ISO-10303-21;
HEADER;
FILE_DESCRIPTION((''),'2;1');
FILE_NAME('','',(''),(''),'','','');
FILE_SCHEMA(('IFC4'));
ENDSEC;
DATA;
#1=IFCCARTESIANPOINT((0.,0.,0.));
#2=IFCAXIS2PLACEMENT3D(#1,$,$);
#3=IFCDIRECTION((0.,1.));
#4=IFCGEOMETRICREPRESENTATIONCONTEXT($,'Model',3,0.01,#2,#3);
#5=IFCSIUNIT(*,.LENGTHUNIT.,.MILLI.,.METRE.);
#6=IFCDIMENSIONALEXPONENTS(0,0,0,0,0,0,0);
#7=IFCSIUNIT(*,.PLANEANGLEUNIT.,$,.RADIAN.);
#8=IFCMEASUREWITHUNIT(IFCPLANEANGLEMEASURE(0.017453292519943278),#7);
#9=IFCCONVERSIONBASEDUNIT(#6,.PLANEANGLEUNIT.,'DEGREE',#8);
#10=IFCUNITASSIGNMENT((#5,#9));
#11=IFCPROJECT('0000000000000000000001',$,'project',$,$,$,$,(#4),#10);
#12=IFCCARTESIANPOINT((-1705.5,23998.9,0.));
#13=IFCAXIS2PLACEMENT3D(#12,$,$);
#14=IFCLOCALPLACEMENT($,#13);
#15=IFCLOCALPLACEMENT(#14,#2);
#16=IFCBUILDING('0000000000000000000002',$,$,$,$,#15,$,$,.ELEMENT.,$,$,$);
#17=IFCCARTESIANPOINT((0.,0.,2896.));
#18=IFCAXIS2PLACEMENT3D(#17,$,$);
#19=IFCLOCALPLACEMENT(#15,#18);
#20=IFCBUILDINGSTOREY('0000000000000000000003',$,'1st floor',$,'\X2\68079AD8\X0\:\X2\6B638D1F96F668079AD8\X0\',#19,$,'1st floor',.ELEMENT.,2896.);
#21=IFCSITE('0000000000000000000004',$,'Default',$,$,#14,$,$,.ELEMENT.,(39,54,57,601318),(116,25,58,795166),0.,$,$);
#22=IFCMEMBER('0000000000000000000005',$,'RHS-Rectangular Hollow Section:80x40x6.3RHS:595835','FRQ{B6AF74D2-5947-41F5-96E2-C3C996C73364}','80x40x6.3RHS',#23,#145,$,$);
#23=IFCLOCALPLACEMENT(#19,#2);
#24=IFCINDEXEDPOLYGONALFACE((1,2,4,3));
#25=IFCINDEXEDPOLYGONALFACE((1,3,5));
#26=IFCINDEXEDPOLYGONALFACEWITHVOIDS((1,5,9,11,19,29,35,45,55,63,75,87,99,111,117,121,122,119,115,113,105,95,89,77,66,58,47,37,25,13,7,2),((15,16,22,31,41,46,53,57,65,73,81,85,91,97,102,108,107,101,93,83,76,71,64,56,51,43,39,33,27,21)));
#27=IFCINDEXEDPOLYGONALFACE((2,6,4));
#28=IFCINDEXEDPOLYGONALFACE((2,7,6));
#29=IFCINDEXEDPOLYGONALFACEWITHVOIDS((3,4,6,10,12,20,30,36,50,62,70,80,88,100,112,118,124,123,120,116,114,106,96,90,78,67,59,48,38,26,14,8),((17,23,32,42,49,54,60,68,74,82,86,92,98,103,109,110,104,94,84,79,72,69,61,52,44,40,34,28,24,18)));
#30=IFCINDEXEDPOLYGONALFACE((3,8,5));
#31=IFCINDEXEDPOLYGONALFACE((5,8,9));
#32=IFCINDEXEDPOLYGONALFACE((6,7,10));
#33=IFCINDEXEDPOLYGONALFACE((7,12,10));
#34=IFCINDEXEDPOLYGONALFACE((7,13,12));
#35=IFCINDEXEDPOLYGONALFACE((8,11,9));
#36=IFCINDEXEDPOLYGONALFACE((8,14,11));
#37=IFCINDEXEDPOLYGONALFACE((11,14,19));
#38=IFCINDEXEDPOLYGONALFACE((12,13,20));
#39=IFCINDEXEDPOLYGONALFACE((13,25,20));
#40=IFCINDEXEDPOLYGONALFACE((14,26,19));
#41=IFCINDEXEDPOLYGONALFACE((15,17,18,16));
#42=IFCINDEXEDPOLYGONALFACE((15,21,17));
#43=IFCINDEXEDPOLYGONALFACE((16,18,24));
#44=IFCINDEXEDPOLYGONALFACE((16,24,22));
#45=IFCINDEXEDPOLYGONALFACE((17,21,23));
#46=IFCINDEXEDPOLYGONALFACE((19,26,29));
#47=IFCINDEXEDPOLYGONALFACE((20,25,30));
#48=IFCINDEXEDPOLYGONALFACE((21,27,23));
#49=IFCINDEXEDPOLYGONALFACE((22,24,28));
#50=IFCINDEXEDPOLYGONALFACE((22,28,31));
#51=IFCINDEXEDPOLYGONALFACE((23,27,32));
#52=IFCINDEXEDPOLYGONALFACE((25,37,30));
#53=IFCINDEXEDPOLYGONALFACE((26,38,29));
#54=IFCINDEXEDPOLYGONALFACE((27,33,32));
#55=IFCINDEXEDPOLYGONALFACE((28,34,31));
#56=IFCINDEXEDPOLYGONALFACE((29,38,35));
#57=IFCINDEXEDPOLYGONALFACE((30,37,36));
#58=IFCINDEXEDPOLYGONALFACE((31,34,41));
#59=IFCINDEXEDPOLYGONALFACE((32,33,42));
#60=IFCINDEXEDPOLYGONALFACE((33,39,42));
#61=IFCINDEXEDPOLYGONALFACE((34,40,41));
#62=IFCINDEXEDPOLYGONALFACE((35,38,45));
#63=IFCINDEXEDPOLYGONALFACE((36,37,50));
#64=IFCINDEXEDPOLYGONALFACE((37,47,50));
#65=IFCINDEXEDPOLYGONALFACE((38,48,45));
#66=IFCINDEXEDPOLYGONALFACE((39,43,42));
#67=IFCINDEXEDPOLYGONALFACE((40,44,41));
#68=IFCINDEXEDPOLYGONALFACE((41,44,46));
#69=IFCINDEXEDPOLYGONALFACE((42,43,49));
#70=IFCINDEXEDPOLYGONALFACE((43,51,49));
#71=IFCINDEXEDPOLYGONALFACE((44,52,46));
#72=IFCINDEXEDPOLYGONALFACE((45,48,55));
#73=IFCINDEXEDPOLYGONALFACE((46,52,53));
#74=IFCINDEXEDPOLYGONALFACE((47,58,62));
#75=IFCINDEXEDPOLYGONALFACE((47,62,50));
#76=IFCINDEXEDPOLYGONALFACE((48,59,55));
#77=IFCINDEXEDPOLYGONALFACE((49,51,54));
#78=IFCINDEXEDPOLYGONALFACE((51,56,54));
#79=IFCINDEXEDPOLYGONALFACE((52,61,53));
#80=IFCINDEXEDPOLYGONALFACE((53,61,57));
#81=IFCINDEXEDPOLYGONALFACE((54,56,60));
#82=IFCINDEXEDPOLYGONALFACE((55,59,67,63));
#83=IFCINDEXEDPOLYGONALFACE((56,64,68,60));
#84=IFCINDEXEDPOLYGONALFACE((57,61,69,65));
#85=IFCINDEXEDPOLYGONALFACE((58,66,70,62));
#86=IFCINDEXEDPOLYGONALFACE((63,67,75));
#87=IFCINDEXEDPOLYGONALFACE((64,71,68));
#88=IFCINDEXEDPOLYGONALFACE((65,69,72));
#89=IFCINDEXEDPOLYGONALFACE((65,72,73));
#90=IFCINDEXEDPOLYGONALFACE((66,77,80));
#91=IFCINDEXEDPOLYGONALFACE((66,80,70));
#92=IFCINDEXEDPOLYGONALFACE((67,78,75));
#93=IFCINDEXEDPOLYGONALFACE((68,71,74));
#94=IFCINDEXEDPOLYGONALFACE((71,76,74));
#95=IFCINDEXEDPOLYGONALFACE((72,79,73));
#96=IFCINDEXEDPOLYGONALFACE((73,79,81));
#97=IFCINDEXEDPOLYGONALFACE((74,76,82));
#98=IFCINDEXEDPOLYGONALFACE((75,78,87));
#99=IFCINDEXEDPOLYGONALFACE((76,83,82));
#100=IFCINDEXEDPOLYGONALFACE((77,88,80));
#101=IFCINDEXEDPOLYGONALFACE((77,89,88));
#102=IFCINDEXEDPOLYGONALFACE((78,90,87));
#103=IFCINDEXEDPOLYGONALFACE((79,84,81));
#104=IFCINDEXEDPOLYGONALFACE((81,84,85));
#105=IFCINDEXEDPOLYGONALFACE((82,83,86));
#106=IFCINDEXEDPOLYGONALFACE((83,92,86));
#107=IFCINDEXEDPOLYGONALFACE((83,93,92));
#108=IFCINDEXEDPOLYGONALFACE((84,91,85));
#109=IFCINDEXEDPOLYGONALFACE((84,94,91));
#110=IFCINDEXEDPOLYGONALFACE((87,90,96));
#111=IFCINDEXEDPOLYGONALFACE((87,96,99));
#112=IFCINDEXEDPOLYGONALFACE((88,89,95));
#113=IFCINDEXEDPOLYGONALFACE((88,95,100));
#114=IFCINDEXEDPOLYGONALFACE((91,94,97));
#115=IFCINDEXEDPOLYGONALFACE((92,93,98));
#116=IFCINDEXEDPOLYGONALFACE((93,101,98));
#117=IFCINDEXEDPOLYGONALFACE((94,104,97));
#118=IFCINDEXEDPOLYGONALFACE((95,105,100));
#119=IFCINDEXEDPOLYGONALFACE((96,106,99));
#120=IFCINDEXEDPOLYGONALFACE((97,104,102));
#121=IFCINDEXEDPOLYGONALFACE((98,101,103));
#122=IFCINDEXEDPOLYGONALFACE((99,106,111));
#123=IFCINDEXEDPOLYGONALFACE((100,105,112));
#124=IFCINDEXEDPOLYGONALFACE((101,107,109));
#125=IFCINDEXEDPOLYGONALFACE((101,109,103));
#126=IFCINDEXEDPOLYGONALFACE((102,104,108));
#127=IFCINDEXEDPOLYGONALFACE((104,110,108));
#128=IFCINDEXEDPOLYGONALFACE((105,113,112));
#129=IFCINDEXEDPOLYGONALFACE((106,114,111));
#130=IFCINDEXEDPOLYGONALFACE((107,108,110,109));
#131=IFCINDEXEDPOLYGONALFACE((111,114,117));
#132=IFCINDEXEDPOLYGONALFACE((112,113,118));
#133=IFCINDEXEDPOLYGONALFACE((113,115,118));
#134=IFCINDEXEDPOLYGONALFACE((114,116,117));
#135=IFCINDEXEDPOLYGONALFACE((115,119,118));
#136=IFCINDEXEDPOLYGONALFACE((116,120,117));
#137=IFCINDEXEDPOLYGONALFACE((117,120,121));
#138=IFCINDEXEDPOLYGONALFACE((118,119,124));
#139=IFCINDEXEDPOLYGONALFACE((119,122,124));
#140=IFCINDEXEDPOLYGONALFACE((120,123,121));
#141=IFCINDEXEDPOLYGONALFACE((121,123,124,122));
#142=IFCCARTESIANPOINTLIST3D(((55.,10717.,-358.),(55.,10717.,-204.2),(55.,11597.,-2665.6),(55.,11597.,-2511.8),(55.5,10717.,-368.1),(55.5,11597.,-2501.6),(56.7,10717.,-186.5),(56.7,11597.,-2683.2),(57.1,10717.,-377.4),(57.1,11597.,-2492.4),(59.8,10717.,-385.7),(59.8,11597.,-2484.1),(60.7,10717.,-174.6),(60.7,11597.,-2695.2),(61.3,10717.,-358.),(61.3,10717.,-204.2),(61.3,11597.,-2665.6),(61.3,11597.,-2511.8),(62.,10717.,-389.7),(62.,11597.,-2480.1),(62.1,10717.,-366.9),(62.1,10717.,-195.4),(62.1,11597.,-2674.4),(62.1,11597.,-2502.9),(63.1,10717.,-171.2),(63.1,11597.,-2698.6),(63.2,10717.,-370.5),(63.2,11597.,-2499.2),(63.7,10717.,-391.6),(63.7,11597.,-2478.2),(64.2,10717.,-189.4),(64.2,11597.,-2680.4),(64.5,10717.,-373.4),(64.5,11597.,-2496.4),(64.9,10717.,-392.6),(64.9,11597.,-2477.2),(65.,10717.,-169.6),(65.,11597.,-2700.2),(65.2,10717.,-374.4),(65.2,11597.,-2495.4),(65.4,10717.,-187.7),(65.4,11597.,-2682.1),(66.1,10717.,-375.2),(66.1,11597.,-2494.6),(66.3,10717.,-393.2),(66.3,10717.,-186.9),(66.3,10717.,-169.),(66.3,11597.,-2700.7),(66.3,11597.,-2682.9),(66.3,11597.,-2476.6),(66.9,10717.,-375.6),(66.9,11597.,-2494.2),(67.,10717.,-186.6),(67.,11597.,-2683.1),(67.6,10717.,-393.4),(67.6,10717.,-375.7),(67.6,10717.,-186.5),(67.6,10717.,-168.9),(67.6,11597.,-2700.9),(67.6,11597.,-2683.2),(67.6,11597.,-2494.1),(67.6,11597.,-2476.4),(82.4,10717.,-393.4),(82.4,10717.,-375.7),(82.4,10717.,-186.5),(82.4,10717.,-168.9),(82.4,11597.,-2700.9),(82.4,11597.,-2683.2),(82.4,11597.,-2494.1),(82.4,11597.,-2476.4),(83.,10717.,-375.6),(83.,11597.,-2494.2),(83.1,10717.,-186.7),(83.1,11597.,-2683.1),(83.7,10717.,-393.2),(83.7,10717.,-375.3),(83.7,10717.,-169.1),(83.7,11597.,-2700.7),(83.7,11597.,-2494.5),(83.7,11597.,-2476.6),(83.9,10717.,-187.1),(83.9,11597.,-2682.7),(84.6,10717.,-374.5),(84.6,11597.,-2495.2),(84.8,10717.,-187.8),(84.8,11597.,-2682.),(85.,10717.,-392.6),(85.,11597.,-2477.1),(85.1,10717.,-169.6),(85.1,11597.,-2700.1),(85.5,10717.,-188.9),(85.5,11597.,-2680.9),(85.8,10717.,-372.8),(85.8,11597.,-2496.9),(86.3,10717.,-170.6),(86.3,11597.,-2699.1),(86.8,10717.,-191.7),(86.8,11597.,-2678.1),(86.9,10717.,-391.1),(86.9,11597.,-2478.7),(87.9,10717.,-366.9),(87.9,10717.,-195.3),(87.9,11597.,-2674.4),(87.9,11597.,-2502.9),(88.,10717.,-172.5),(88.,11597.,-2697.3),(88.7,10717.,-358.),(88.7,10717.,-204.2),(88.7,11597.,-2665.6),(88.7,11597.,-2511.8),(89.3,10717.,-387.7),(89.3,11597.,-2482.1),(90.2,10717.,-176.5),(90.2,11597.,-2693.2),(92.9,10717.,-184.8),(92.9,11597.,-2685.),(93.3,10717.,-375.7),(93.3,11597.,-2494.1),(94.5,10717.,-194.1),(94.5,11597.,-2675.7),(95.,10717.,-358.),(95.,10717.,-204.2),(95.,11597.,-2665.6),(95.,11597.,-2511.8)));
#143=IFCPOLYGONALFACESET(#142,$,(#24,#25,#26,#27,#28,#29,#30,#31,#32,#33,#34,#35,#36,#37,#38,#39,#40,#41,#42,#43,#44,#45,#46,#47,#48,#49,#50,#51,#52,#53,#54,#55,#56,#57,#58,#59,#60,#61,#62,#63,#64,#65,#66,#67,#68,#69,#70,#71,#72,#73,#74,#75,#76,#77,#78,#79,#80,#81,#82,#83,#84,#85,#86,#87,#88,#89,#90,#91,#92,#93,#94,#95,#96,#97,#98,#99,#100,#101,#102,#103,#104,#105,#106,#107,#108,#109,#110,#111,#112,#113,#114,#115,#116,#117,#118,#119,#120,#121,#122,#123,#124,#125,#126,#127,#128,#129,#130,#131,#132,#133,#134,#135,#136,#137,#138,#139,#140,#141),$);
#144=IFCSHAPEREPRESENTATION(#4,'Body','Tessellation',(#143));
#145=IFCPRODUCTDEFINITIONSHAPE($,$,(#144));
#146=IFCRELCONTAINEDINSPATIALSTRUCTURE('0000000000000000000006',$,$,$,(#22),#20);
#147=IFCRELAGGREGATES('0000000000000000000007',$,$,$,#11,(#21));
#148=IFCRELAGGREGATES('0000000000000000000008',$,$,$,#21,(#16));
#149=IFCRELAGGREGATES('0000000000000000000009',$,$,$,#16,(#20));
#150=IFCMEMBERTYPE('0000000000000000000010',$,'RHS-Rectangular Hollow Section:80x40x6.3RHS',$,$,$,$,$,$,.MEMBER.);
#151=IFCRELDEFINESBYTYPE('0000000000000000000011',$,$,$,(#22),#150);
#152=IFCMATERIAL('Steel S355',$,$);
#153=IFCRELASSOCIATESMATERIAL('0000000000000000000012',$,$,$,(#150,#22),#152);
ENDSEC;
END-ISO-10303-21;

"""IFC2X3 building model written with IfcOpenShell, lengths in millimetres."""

from ifc_helpers import new_model, entity, si_unit, converted_unit, direction, frame, origin, origin_2d, place, context, project, spatial, hollow_rectangle, extrude, clip, halfspace, material, type_object, element, save


model = new_model("IFC2X3")

# Units and contexts
model_context = context("Model", 3, precision=0.01, world=origin(), true_north=direction((0.0, 1.0)))
ifc_project = project(units=[si_unit("LENGTHUNIT", "METRE", prefix="MILLI"), converted_unit("PLANEANGLEUNIT", "DEGREE", entity("IfcPlaneAngleMeasure", 0.017453292519943278), si_unit("PLANEANGLEUNIT", "RADIAN"), dimensions=[0, 0, 0, 0, 0, 0, 0])], contexts=[model_context])

# Site, building, storey
site_placement = place(None, frame((-1705.5, 23998.9, 0.0)))
site = spatial("IfcSite", under=ifc_project, at=site_placement, Name="Default", CompositionType="ELEMENT", RefLatitude=(39, 54, 57, 601318), RefLongitude=(116, 25, 58, 795166), RefElevation=0.0)
building_placement = place(site_placement, origin())
building = spatial("IfcBuilding", under=site, at=building_placement, CompositionType="ELEMENT")
storey_placement = place(building_placement, frame((0.0, 0.0, 2896.0)))
storey = spatial("IfcBuildingStorey", under=building, at=storey_placement, Name="1st floor", ObjectType="标高:正负零标高", LongName="1st floor", CompositionType="ELEMENT", Elevation=2896.0)

# Shared definitions
ifc_material_1 = material(Name="Steel S355")

# Member
member_type = type_object("IfcMemberType", Name="RHS-Rectangular Hollow Section:80x40x6.3RHS", PredefinedType="MEMBER", material=ifc_material_1)
member_1_placement = place(storey_placement, frame((75.0, 11701.7, -2863.3), z_axis=(0.0, 0.356325, -0.934362), x_axis=(-1.0, 0.0, 0.0)))
element("IfcMember", 1, at=member_1_placement, inside=storey, type_object=member_type, material=ifc_material_1, Name="RHS-Rectangular Hollow Section:80x40x6.3RHS:595835", Description="FRQ{B6AF74D2-5947-41F5-96E2-C3C996C73364}", ObjectType="80x40x6.3RHS", context=model_context, shape_type="Clipping", body=[
    clip(clip(extrude(hollow_rectangle(XDim=40.0, YDim=80.0, WallThickness=6.3, InnerFilletRadius=6.3, OuterFilletRadius=12.6, at=origin_2d()), origin(), (0.0, 0.0, -1.0), 3029.4), halfspace(frame((75.0, -109.5, -6.7), z_axis=(0.0, -0.934362, -0.356325), x_axis=(-1.0, 0.0, 0.0)), True)), halfspace(frame((75.0, -931.7, -320.3), z_axis=(0.0, 0.934362, 0.356325), x_axis=(1.0, 0.0, 0.0)), True)),
])

save(model, "model.ifc")
